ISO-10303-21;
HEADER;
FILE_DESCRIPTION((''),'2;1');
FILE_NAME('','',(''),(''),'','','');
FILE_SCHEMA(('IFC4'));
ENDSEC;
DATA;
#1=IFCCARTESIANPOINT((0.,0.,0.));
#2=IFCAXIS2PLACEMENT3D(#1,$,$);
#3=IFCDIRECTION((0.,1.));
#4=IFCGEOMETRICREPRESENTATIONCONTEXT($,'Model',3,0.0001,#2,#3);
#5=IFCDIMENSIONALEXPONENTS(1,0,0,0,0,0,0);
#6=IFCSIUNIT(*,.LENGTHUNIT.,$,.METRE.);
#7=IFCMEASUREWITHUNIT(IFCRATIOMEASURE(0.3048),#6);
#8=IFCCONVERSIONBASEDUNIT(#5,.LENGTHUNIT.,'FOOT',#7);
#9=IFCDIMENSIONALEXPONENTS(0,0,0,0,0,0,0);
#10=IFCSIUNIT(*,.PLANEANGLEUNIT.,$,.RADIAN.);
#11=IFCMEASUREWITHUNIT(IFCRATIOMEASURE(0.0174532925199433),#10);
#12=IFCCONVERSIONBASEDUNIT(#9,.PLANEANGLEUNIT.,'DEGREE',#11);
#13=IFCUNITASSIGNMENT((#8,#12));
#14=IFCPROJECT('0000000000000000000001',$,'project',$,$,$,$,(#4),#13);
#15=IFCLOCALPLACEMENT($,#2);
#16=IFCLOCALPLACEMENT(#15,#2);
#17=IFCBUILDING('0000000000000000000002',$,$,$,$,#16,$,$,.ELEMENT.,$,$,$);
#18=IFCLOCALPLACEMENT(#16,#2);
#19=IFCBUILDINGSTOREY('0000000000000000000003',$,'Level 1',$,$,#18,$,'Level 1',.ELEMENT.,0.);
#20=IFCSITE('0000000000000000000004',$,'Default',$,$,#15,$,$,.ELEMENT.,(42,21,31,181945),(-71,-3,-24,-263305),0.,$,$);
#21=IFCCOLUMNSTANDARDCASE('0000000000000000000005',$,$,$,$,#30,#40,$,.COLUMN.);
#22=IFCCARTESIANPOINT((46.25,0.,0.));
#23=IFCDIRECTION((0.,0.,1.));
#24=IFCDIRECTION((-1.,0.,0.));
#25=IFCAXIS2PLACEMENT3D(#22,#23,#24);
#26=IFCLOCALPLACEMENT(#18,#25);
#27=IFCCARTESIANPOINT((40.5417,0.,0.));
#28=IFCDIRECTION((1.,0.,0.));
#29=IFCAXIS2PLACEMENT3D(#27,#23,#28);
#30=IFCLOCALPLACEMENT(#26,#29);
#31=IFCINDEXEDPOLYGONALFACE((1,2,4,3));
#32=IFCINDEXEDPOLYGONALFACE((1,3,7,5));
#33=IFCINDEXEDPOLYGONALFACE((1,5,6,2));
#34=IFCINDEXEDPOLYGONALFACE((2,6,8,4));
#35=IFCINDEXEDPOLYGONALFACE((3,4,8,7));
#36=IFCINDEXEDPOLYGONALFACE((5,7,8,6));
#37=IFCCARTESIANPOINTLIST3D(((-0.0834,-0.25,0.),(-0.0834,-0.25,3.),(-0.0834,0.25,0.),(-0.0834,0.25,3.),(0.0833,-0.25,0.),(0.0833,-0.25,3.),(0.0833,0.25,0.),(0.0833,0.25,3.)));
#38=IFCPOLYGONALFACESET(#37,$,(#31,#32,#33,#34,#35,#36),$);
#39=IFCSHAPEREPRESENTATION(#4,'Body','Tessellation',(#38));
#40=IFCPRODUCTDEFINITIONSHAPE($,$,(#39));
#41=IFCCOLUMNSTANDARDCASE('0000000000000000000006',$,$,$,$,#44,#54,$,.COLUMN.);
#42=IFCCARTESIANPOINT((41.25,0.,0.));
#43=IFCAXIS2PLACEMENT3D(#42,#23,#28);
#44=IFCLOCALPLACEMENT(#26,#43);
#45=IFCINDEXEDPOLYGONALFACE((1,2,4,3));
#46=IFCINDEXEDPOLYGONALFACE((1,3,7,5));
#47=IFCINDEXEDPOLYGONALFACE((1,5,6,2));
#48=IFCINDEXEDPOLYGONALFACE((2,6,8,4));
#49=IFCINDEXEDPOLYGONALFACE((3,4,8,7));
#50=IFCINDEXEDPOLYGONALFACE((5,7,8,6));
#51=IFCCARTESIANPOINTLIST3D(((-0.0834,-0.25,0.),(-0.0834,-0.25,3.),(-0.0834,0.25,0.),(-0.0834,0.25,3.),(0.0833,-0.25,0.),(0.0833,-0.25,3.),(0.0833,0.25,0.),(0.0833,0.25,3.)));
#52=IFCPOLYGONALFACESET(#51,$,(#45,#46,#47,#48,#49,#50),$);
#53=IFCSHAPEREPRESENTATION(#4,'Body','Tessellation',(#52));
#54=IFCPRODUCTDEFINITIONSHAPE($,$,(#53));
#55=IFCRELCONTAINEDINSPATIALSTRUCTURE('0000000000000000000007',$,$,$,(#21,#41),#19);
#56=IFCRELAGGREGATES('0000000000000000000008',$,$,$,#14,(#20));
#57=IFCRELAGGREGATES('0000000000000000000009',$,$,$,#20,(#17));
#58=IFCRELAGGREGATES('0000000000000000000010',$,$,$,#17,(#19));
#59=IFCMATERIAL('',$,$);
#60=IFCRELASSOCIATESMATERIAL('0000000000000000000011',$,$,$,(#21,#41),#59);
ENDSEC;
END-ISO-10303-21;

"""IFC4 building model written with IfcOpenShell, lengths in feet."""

from ifc_helpers import new_model, entity, si_unit, converted_unit, direction, frame, origin, place, context, project, spatial, rectangle, extrude, material, element, save


model = new_model("IFC4")

# Units and contexts
model_context = context("Model", 3, precision=0.0001, world=origin(), true_north=direction((0.0, 1.0)))
ifc_project = project(units=[converted_unit("LENGTHUNIT", "FOOT", entity("IfcRatioMeasure", 0.3048), si_unit("LENGTHUNIT", "METRE"), dimensions=[1, 0, 0, 0, 0, 0, 0]), converted_unit("PLANEANGLEUNIT", "DEGREE", entity("IfcRatioMeasure", 0.0174532925199433), si_unit("PLANEANGLEUNIT", "RADIAN"), dimensions=[0, 0, 0, 0, 0, 0, 0])], contexts=[model_context])

# Site, building, storey
site_placement = place(None, origin())
site = spatial("IfcSite", under=ifc_project, at=site_placement, Name="Default", CompositionType="ELEMENT", RefLatitude=(42, 21, 31, 181945), RefLongitude=(-71, -3, -24, -263305), RefElevation=0.0)
building_placement = place(site_placement, origin())
building = spatial("IfcBuilding", under=site, at=building_placement, CompositionType="ELEMENT")
storey_placement = place(building_placement, origin())
storey = spatial("IfcBuildingStorey", under=building, at=storey_placement, Name="Level 1", LongName="Level 1", CompositionType="ELEMENT", Elevation=0.0)

# Columns
ifc_material_1 = material(Name="")
placement_1 = place(storey_placement, frame((46.25, 0.0, 0.0), z_axis=(0.0, 0.0, 1.0), x_axis=(-1.0, 0.0, 0.0)))
for number, where, z_axis, x_axis in (
    (1, (40.5417, 0.0, 0.0), (0.0, 0.0, 1.0), (1.0, 0.0, 0.0)),
    (2, (41.25, 0.0, 0.0), (0.0, 0.0, 1.0), (1.0, 0.0, 0.0)),
):
    element("IfcColumnStandardCase", number, at=place(placement_1, frame(where, z_axis=z_axis, x_axis=x_axis)), inside=storey, material=ifc_material_1, PredefinedType="COLUMN", context=model_context, shape_type="SweptSolid", body=[
        extrude(rectangle(XDim=0.1667, YDim=0.5), origin(), (0.0, 0.0, 1.0), 3.0),
    ])

save(model, "model.ifc")
